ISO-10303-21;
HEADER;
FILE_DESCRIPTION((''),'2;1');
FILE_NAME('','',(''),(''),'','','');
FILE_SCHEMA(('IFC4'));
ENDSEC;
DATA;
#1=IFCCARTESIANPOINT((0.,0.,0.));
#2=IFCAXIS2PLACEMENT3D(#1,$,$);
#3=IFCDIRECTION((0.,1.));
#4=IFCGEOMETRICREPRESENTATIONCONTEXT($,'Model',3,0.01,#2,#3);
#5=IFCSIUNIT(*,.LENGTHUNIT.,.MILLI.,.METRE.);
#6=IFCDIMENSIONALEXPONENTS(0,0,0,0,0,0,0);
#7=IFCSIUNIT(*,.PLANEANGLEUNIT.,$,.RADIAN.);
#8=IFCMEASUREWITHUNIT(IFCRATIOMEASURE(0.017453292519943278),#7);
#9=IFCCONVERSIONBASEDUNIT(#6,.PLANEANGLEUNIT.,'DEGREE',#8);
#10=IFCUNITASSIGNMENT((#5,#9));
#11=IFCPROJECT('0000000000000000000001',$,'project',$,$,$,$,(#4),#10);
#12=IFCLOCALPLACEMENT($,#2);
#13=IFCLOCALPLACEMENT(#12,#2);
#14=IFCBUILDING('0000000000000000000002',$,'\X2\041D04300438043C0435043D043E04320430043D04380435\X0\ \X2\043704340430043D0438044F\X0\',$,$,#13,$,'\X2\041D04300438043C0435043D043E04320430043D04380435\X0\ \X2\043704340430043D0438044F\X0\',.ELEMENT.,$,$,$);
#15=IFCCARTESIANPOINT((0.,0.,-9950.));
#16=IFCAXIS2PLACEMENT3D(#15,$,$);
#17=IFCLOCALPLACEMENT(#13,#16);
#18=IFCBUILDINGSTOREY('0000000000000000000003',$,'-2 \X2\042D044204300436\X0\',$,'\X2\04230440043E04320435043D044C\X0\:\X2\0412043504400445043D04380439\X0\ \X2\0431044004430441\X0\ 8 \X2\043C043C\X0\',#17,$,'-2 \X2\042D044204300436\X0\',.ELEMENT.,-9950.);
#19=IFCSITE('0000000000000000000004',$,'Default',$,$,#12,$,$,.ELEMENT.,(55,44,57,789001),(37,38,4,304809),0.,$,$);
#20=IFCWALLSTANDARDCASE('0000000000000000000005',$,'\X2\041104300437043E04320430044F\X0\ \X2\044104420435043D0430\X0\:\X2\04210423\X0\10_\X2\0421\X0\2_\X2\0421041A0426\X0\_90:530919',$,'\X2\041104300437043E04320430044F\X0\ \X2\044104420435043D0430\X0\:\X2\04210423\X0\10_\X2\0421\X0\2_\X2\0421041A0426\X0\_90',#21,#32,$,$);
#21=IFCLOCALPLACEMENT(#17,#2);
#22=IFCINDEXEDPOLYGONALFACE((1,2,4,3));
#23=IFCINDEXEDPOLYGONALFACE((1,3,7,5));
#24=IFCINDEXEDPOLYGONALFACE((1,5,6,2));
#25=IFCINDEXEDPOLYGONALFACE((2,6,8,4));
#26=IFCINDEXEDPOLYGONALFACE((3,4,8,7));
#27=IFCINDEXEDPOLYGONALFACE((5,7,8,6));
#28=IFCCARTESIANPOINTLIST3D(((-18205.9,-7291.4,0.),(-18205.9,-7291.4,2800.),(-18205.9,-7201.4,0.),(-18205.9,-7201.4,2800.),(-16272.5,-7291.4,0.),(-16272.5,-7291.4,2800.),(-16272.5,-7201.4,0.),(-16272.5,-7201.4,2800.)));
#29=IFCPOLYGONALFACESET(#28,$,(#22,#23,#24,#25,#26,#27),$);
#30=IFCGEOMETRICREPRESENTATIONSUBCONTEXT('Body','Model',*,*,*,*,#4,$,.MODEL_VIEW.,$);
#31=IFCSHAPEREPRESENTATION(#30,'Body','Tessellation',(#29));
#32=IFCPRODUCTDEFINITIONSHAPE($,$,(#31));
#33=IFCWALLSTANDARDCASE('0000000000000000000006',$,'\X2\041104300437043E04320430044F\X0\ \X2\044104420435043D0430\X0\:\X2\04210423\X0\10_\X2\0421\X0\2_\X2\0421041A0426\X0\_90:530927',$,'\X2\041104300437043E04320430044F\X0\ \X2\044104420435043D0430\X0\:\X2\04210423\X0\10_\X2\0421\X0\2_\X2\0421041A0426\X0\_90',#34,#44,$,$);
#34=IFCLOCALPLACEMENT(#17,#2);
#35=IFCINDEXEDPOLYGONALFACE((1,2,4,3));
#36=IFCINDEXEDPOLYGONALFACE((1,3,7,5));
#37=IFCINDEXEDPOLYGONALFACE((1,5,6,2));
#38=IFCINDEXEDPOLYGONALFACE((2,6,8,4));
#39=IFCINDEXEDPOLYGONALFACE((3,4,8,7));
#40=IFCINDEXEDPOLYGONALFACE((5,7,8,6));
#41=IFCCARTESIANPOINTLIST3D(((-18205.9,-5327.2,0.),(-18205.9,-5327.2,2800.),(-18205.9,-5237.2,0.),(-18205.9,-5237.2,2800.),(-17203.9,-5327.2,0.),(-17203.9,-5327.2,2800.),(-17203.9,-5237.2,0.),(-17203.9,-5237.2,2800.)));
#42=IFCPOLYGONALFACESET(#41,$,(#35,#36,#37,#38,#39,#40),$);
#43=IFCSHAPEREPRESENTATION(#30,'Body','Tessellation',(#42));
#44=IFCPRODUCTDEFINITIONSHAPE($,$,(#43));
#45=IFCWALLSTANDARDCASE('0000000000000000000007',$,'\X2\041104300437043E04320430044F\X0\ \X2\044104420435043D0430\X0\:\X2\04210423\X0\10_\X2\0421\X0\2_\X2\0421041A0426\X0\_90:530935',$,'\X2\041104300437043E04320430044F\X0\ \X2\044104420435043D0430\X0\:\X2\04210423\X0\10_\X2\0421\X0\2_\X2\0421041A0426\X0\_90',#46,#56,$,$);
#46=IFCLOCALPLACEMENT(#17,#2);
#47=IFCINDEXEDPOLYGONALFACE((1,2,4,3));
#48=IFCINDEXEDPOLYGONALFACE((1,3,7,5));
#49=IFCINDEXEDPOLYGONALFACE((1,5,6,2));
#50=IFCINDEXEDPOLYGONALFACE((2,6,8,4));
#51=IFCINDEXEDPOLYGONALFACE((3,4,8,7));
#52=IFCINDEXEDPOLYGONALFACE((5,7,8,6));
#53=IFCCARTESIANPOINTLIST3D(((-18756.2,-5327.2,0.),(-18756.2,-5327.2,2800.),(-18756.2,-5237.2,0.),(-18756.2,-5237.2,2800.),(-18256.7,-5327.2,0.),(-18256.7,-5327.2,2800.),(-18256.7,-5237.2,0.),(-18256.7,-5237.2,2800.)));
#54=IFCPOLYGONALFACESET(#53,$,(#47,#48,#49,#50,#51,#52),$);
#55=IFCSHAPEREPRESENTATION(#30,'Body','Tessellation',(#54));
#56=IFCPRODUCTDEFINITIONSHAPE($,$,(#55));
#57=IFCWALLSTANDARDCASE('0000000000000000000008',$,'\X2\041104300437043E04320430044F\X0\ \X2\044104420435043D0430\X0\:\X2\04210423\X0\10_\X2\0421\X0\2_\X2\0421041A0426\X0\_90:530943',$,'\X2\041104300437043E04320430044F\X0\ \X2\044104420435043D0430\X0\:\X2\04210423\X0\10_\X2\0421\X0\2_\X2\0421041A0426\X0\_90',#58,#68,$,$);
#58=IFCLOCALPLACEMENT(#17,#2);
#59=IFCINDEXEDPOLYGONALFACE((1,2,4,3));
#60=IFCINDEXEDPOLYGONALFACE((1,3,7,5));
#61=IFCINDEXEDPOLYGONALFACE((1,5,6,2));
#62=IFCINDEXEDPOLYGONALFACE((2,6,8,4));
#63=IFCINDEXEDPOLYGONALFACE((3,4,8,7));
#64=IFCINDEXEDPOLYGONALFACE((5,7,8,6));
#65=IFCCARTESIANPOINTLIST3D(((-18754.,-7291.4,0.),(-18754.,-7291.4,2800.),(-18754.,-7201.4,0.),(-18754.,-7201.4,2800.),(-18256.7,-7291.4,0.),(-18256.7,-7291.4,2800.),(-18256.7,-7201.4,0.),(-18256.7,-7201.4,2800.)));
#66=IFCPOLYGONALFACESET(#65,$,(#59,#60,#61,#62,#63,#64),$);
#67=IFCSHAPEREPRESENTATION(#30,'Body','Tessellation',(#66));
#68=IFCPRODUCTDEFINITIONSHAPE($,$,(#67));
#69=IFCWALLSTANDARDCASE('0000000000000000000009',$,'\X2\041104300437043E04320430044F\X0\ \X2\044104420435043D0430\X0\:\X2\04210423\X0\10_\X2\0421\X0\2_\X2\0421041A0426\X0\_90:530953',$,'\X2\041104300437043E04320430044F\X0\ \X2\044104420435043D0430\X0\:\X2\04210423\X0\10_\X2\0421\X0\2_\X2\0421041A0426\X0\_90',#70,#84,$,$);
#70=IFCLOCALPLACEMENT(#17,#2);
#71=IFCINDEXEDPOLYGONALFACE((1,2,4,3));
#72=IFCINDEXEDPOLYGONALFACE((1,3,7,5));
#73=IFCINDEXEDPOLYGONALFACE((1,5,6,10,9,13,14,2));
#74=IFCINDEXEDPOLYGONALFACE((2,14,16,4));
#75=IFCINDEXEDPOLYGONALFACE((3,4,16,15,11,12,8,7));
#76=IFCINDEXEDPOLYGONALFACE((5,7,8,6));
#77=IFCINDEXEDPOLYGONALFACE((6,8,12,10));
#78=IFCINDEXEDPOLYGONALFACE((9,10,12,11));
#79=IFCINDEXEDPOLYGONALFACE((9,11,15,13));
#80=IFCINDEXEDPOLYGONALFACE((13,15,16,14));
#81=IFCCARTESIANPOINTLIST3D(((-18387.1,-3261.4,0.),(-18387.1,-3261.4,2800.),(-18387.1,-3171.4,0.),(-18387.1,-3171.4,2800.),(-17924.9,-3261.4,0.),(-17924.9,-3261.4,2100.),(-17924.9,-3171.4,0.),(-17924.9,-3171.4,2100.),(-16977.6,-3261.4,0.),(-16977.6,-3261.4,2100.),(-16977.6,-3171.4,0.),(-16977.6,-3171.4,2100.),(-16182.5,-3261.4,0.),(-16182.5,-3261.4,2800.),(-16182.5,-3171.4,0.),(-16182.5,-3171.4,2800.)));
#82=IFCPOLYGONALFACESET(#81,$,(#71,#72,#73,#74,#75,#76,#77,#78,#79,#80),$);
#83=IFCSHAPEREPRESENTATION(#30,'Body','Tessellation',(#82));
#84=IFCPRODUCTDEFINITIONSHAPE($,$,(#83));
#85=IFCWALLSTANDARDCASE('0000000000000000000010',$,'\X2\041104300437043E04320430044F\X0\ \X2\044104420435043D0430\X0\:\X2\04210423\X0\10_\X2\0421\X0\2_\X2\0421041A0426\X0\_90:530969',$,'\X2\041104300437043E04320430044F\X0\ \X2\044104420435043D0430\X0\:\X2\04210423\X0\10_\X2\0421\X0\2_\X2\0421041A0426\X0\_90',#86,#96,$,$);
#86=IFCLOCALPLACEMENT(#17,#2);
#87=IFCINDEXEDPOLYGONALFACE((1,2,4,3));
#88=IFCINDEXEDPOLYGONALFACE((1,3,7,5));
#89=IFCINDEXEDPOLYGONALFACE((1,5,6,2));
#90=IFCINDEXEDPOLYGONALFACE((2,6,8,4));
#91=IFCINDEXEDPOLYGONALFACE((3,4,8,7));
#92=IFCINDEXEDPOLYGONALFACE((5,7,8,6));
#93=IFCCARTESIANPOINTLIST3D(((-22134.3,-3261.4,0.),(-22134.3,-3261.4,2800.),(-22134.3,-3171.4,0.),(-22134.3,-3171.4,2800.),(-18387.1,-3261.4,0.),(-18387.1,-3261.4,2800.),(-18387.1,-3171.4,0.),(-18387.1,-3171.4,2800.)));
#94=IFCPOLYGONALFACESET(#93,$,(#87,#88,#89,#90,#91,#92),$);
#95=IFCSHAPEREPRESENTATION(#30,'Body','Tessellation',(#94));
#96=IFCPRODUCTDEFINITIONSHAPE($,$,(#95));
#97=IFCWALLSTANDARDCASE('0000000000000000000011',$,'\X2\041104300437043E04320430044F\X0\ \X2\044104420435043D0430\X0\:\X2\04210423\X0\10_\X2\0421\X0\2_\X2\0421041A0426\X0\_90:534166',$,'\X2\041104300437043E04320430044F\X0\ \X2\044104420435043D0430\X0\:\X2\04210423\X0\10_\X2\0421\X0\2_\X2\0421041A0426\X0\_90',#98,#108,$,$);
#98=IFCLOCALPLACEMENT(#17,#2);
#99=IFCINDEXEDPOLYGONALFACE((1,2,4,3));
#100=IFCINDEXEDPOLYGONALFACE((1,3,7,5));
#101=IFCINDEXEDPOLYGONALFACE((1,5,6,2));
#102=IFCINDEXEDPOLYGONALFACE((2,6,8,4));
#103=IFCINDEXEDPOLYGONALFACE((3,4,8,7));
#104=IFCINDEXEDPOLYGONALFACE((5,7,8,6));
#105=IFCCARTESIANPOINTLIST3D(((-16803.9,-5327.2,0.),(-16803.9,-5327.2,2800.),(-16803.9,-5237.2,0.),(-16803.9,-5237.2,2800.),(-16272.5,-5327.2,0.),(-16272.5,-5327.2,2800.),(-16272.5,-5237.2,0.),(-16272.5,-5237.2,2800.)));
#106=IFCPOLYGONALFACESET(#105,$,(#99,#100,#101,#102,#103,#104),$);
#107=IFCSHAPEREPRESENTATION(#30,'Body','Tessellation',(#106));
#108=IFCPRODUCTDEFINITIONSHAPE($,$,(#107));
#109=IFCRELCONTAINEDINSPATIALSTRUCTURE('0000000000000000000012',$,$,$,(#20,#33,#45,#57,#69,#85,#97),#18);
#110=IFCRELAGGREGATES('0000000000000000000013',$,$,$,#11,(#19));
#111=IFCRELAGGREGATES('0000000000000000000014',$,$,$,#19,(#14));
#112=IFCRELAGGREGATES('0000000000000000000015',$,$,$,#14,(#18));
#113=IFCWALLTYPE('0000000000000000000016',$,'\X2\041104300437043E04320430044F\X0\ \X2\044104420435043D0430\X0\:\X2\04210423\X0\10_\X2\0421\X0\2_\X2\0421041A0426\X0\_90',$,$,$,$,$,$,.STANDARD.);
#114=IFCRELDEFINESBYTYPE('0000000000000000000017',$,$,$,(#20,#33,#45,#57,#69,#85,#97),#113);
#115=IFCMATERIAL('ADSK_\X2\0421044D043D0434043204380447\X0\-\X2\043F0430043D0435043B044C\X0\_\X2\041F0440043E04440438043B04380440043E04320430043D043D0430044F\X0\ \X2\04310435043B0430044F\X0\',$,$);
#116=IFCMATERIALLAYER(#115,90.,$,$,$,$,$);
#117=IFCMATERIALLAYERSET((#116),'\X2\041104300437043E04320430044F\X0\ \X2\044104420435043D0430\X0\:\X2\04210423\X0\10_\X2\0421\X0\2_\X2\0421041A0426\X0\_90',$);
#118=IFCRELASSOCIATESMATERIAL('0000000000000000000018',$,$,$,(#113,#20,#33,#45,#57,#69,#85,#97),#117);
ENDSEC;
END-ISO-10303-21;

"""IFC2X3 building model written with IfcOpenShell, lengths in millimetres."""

from ifc_helpers import new_model, entity, si_unit, converted_unit, direction, frame, frame_2d, origin, place, context, subcontext, project, spatial, rectangle, extrude, material, layer, layer_set, layer_usage, type_object, element, save


model = new_model("IFC2X3")

# Units and contexts
model_context = context("Model", 3, precision=0.01, world=origin(), true_north=direction((0.0, 1.0)))
body_context = subcontext(model_context, "Body", "Model", "MODEL_VIEW")
ifc_project = project(units=[si_unit("LENGTHUNIT", "METRE", prefix="MILLI"), converted_unit("PLANEANGLEUNIT", "DEGREE", entity("IfcRatioMeasure", 0.017453292519943278), si_unit("PLANEANGLEUNIT", "RADIAN"), dimensions=[0, 0, 0, 0, 0, 0, 0])], contexts=[model_context])

# Site, building, storey
site_placement = place(None, origin())
site = spatial("IfcSite", under=ifc_project, at=site_placement, Name="Default", CompositionType="ELEMENT", RefLatitude=(55, 44, 57, 789001), RefLongitude=(37, 38, 4, 304809), RefElevation=0.0)
building_placement = place(site_placement, origin())
building = spatial("IfcBuilding", under=site, at=building_placement, Name="Наименование здания", LongName="Наименование здания", CompositionType="ELEMENT")
storey_placement = place(building_placement, frame((0.0, 0.0, -9950.0)))
storey = spatial("IfcBuildingStorey", under=building, at=storey_placement, Name="-2 Этаж", ObjectType="Уровень:Верхний брус 8 мм", LongName="-2 Этаж", CompositionType="ELEMENT", Elevation=-9950.0)

# Shared definitions
ifc_material_1 = material(Name="ADSK_Сэндвич-панель_Профилированная белая")
ifc_layer_1 = layer(ifc_material_1, 90.0)
ifc_layer_set_1 = layer_set([ifc_layer_1], Name="Базовая стена:СУ10_С2_СКЦ_90")
ifc_layer_usage_1 = layer_usage(ifc_layer_set_1, "AXIS2", "NEGATIVE", 45.0)
wall_type_1 = type_object("IfcWallType", Name="Базовая стена:СУ10_С2_СКЦ_90", PredefinedType="STANDARD", material=ifc_layer_set_1)

# Walls
wall_1_placement = place(storey_placement, frame((-16272.5, -7246.4, 0.0), z_axis=(0.0, 0.0, 1.0), x_axis=(-1.0, 0.0, 0.0)))
element("IfcWallStandardCase", 1, at=wall_1_placement, inside=storey, type_object=wall_type_1, material=ifc_layer_usage_1, Name="Базовая стена:СУ10_С2_СКЦ_90:530919", ObjectType="Базовая стена:СУ10_С2_СКЦ_90", context=body_context, shape_type="SweptSolid", body=[
    extrude(rectangle(XDim=1933.5, YDim=90.0, at=frame_2d((966.7, 0.0), x_axis=(-1.0, 0.0))), origin(), (0.0, 0.0, 1.0), 2800.0),
])
wall_2_placement = place(storey_placement, frame((-17203.9, -5282.2, 0.0), z_axis=(0.0, 0.0, 1.0), x_axis=(-1.0, 0.0, 0.0)))
element("IfcWallStandardCase", 2, at=wall_2_placement, inside=storey, type_object=wall_type_1, material=ifc_layer_usage_1, Name="Базовая стена:СУ10_С2_СКЦ_90:530927", ObjectType="Базовая стена:СУ10_С2_СКЦ_90", context=body_context, shape_type="SweptSolid", body=[
    extrude(rectangle(XDim=1002.0, YDim=90.0, at=frame_2d((501.0, 0.0), x_axis=(-1.0, 0.0))), origin(), (0.0, 0.0, 1.0), 2800.0),
])
wall_3_placement = place(storey_placement, frame((-18256.7, -5282.2, 0.0), z_axis=(0.0, 0.0, 1.0), x_axis=(-1.0, 0.0, 0.0)))
element("IfcWallStandardCase", 3, at=wall_3_placement, inside=storey, type_object=wall_type_1, material=ifc_layer_usage_1, Name="Базовая стена:СУ10_С2_СКЦ_90:530935", ObjectType="Базовая стена:СУ10_С2_СКЦ_90", context=body_context, shape_type="SweptSolid", body=[
    extrude(rectangle(XDim=499.5, YDim=90.0, at=frame_2d((249.8, 0.0), x_axis=(-1.0, 0.0))), origin(), (0.0, 0.0, 1.0), 2800.0),
])
wall_4_placement = place(storey_placement, frame((-18256.7, -7246.4, 0.0), z_axis=(0.0, 0.0, 1.0), x_axis=(-1.0, 0.0, 0.0)))
element("IfcWallStandardCase", 4, at=wall_4_placement, inside=storey, type_object=wall_type_1, material=ifc_layer_usage_1, Name="Базовая стена:СУ10_С2_СКЦ_90:530943", ObjectType="Базовая стена:СУ10_С2_СКЦ_90", context=body_context, shape_type="SweptSolid", body=[
    extrude(rectangle(XDim=497.2, YDim=90.0, at=frame_2d((248.6, 0.0), x_axis=(-1.0, 0.0))), origin(), (0.0, 0.0, 1.0), 2800.0),
])

# Wall, opening
wall_5_placement = place(storey_placement, frame((-16182.5, -3216.4, 0.0), z_axis=(0.0, 0.0, 1.0), x_axis=(-1.0, 0.0, 0.0)))
wall_5 = element("IfcWallStandardCase", 5, at=wall_5_placement, inside=storey, type_object=wall_type_1, material=ifc_layer_usage_1, Name="Базовая стена:СУ10_С2_СКЦ_90:530953", ObjectType="Базовая стена:СУ10_С2_СКЦ_90", context=body_context, shape_type="SweptSolid", body=[
    extrude(rectangle(XDim=2204.7, YDim=90.0, at=frame_2d((1102.3, 0.0), x_axis=(1.0, 0.0))), origin(), (0.0, 0.0, 1.0), 2800.0),
])
opening_1_placement = place(wall_5_placement, origin())
element("IfcOpeningElement", 6, at=opening_1_placement, cuts=wall_5, ObjectType="Opening", context=body_context, shape_type="SweptSolid", body=[
    extrude(rectangle(XDim=2100.0, YDim=947.3, at=frame_2d((0.0, 0.0), x_axis=(1.0, 0.0))), frame((1268.8, -45.0, 1050.0), z_axis=(0.0, 1.0, 0.0), x_axis=(0.0, 0.0, -1.0)), (0.0, 0.0, 1.0), 90.0),
])

# Walls
wall_6_placement = place(storey_placement, frame((-18387.1, -3216.4, 0.0), z_axis=(0.0, 0.0, 1.0), x_axis=(-1.0, 0.0, 0.0)))
element("IfcWallStandardCase", 7, at=wall_6_placement, inside=storey, type_object=wall_type_1, material=ifc_layer_usage_1, Name="Базовая стена:СУ10_С2_СКЦ_90:530969", ObjectType="Базовая стена:СУ10_С2_СКЦ_90", context=body_context, shape_type="SweptSolid", body=[
    extrude(rectangle(XDim=3747.2, YDim=90.0, at=frame_2d((1873.6, 0.0), x_axis=(-1.0, 0.0))), origin(), (0.0, 0.0, 1.0), 2800.0),
])
wall_7_placement = place(storey_placement, frame((-16272.5, -5282.2, 0.0), z_axis=(0.0, 0.0, 1.0), x_axis=(-1.0, 0.0, 0.0)))
element("IfcWallStandardCase", 8, at=wall_7_placement, inside=storey, type_object=wall_type_1, material=ifc_layer_usage_1, Name="Базовая стена:СУ10_С2_СКЦ_90:534166", ObjectType="Базовая стена:СУ10_С2_СКЦ_90", context=body_context, shape_type="SweptSolid", body=[
    extrude(rectangle(XDim=531.5, YDim=90.0, at=frame_2d((265.7, 0.0), x_axis=(-1.0, 0.0))), origin(), (0.0, 0.0, 1.0), 2800.0),
])

save(model, "model.ifc")
